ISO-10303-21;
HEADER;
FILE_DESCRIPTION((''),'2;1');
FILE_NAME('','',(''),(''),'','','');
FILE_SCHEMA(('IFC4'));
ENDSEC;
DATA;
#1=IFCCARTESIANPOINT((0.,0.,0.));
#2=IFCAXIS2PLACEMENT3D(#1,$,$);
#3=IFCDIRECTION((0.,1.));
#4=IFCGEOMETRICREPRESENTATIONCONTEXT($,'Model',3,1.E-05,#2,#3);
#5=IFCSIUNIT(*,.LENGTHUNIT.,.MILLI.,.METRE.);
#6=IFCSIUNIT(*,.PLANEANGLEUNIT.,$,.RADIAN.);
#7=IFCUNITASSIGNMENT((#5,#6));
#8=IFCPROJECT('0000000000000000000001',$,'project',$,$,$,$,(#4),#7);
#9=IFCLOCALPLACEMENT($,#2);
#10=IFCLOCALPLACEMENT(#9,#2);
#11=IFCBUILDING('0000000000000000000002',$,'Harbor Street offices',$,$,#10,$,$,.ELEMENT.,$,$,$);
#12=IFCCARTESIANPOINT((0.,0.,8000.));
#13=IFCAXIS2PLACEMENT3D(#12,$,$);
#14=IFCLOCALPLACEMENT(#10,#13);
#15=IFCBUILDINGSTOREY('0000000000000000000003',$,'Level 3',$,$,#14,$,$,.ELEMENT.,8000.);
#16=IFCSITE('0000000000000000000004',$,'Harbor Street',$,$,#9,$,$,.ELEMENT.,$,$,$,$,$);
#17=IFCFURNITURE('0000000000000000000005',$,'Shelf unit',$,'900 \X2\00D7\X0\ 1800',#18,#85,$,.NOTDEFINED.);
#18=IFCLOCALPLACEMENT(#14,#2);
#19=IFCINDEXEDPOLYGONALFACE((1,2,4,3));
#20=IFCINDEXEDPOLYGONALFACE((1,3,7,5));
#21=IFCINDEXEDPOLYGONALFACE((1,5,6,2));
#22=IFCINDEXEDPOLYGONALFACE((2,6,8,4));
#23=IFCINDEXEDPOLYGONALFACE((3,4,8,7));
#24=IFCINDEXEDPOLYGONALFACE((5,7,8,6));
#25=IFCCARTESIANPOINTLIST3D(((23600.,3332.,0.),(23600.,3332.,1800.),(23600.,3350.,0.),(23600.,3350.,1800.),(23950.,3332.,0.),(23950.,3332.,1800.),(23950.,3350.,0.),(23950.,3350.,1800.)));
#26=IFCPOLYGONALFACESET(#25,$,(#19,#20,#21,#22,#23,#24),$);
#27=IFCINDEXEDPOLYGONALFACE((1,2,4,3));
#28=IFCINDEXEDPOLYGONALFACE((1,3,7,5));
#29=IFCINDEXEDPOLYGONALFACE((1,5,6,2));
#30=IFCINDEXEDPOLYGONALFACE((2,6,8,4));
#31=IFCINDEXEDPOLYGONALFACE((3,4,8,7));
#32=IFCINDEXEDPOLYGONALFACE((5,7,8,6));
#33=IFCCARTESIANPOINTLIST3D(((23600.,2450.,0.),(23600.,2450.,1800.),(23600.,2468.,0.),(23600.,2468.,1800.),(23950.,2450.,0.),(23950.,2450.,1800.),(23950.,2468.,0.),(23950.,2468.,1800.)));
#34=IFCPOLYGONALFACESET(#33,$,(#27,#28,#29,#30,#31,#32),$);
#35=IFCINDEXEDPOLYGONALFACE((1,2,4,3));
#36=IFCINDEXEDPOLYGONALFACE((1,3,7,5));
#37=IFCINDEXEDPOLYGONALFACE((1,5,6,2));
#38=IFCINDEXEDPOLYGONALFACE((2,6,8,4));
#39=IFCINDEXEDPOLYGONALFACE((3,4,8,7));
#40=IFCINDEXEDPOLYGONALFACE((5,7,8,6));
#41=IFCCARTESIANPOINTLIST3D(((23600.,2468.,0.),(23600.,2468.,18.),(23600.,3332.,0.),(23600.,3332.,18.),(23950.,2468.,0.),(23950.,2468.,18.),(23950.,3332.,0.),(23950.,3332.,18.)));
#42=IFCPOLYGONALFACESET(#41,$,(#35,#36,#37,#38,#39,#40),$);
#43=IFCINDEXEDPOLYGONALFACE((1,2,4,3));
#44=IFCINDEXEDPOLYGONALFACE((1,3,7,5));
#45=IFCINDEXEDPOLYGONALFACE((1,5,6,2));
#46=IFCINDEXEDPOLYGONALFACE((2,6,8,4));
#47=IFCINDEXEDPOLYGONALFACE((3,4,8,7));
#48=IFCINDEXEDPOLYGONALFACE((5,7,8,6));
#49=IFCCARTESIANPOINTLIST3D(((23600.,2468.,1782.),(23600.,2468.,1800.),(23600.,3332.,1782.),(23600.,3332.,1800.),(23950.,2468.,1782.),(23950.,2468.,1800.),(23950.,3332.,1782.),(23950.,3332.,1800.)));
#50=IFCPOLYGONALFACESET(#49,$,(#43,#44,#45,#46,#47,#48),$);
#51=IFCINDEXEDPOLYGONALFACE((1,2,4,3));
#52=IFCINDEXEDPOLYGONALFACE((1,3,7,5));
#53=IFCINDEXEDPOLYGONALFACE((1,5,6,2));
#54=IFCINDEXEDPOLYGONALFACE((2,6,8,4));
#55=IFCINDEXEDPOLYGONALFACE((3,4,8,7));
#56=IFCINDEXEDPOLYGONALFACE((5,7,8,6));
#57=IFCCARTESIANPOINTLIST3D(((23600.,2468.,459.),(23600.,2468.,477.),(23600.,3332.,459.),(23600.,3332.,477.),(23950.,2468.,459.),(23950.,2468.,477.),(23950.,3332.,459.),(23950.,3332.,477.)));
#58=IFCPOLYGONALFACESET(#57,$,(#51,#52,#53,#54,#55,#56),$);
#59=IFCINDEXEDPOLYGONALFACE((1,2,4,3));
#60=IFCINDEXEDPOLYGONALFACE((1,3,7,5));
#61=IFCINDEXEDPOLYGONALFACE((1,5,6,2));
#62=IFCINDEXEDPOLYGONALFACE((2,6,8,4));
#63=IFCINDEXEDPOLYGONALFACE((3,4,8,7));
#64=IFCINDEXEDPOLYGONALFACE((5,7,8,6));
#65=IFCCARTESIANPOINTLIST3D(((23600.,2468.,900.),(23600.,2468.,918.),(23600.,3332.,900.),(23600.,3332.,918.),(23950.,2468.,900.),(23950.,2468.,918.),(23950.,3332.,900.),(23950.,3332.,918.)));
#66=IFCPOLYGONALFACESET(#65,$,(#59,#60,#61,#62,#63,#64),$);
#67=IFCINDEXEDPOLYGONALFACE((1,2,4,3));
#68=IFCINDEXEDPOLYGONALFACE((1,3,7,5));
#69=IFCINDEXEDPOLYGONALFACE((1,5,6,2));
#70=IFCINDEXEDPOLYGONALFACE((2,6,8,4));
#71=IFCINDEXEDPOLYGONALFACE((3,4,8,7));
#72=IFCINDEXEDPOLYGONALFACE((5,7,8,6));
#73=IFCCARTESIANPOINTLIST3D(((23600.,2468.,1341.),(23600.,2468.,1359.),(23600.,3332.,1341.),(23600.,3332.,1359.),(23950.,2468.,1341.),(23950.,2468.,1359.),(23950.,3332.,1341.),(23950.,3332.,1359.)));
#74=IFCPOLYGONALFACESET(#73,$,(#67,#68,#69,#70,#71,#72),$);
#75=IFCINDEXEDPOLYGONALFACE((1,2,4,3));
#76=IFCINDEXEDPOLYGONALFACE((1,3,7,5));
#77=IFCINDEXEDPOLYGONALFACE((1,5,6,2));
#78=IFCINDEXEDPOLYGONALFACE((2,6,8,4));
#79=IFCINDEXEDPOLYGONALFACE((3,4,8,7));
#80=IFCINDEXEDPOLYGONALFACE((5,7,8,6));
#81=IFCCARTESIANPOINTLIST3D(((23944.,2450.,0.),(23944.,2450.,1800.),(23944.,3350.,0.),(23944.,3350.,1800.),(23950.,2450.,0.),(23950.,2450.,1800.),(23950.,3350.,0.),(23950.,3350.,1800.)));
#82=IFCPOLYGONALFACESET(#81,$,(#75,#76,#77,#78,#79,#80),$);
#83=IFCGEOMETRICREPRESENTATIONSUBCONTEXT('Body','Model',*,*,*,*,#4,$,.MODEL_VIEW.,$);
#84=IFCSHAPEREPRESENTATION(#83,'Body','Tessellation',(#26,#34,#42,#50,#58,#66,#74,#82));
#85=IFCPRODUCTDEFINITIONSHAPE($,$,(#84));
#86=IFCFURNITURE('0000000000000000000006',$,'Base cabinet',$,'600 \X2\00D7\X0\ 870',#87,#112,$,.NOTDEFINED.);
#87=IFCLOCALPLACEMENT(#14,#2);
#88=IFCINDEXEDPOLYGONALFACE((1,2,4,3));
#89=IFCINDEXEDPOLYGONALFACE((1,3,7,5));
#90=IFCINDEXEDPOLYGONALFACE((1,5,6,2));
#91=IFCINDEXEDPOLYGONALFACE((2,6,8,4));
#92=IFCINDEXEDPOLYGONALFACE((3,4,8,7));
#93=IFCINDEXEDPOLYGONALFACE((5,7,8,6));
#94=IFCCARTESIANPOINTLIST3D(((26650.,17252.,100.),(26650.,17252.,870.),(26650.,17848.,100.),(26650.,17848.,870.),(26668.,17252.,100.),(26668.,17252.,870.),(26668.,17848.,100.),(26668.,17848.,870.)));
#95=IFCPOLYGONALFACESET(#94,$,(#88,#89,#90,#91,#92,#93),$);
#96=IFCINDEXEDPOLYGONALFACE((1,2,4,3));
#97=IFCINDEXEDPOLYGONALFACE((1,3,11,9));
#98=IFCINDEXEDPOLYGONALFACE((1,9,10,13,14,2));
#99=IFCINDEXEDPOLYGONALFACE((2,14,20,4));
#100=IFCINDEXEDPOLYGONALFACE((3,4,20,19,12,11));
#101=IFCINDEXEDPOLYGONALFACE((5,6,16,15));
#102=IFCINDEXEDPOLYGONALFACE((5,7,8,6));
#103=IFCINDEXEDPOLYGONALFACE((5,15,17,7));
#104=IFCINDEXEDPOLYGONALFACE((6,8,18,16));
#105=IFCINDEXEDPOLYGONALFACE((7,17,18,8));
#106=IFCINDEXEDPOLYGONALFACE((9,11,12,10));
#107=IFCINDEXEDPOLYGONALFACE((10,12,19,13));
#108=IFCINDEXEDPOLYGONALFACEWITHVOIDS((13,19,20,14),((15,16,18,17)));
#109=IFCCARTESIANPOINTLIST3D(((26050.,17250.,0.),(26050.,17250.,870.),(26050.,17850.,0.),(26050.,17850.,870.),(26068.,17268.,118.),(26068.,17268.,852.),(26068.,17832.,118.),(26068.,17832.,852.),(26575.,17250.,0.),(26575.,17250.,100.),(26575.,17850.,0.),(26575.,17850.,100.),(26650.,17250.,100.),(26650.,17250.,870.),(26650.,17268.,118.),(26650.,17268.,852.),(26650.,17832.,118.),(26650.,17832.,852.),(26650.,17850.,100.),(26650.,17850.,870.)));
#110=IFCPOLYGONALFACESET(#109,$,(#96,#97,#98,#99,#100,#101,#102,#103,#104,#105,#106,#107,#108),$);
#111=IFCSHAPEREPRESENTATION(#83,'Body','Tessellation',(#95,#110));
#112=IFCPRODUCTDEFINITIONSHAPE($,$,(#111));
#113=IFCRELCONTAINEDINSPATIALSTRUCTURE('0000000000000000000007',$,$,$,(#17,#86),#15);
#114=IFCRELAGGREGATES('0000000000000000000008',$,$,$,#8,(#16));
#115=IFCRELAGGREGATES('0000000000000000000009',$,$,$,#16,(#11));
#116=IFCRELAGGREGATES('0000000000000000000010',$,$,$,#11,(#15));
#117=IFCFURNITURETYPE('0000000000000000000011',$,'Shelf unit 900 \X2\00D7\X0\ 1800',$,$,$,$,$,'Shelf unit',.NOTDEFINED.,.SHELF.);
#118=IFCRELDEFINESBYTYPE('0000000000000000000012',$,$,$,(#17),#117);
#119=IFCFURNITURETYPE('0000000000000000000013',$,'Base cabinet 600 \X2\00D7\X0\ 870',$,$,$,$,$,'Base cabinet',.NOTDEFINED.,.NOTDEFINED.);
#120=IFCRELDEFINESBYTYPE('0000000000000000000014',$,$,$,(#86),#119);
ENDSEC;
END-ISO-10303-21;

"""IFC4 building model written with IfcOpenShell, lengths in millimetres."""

from ifc_helpers import new_model, entity, si_unit, direction, frame, origin, place, context, subcontext, project, spatial, polyline, outline, extrude, source, transform, mapped, type_object, type_shapes, element, save


model = new_model("IFC4")

# Units and contexts
model_context = context("Model", 3, precision=1e-05, world=origin(), true_north=direction((0.0, 1.0)))
body_context = subcontext(model_context, "Body", "Model", "MODEL_VIEW")
ifc_project = project(units=[si_unit("LENGTHUNIT", "METRE", prefix="MILLI"), si_unit("PLANEANGLEUNIT", "RADIAN")], contexts=[model_context])

# Site, building, storey
site_placement = place(None, origin())
site = spatial("IfcSite", under=ifc_project, at=site_placement, Name="Harbor Street", CompositionType="ELEMENT")
building_placement = place(site_placement, origin())
building = spatial("IfcBuilding", under=site, at=building_placement, Name="Harbor Street offices", CompositionType="ELEMENT")
storey_placement = place(building_placement, frame((0.0, 0.0, 8000.0)))
storey = spatial("IfcBuildingStorey", under=building, at=storey_placement, Name="Level 3", CompositionType="ELEMENT", Elevation=8000.0)

# Furniture
furniture_type_1 = type_object("IfcFurnitureType", Name="Shelf unit 900 × 1800", ElementType="Shelf unit", AssemblyPlace="NOTDEFINED", PredefinedType="SHELF")
shared_shape_1 = source(origin(), body_context, "Body", "SweptSolid", [
    extrude(outline(polyline([(-450.0, 0.0), (-432.0, 0.0), (-432.0, 350.0), (-450.0, 350.0), (-450.0, 0.0)])), origin(), (0.0, 0.0, 1.0), 1800.0),
    extrude(outline(polyline([(432.0, 0.0), (450.0, 0.0), (450.0, 350.0), (432.0, 350.0), (432.0, 0.0)])), origin(), (0.0, 0.0, 1.0), 1800.0),
    extrude(outline(polyline([(-432.0, 0.0), (432.0, 0.0), (432.0, 350.0), (-432.0, 350.0), (-432.0, 0.0)])), origin(), (0.0, 0.0, 1.0), 18.0),
    extrude(outline(polyline([(-432.0, 0.0), (432.0, 0.0), (432.0, 350.0), (-432.0, 350.0), (-432.0, 0.0)])), frame((0.0, 0.0, 1782.0)), (0.0, 0.0, 1.0), 18.0),
    extrude(outline(polyline([(-432.0, 0.0), (432.0, 0.0), (432.0, 350.0), (-432.0, 350.0), (-432.0, 0.0)])), frame((0.0, 0.0, 459.0)), (0.0, 0.0, 1.0), 18.0),
    extrude(outline(polyline([(-432.0, 0.0), (432.0, 0.0), (432.0, 350.0), (-432.0, 350.0), (-432.0, 0.0)])), frame((0.0, 0.0, 900.0)), (0.0, 0.0, 1.0), 18.0),
    extrude(outline(polyline([(-432.0, 0.0), (432.0, 0.0), (432.0, 350.0), (-432.0, 350.0), (-432.0, 0.0)])), frame((0.0, 0.0, 1341.0)), (0.0, 0.0, 1.0), 18.0),
    extrude(outline(polyline([(-450.0, 344.0), (450.0, 344.0), (450.0, 350.0), (-450.0, 350.0), (-450.0, 344.0)])), origin(), (0.0, 0.0, 1.0), 1800.0),
])
type_shapes(furniture_type_1, [shared_shape_1])
for number, where, z_axis, x_axis, name in (
    (1, (23600.0, 2900.0, 0.0), (0.0, 0.0, 1.0), (0.0, -1.0, 0.0), "Shelf unit"),
):
    element("IfcFurniture", number, at=place(storey_placement, frame(where, z_axis=z_axis, x_axis=x_axis)), inside=storey, type_object=furniture_type_1, Name=name, ObjectType="900 × 1800", PredefinedType="NOTDEFINED", context=body_context, shape_type="MappedRepresentation", body=[
        mapped(shared_shape_1, transform((0.0, 0.0, 0.0))),
    ])
furniture_type_2 = type_object("IfcFurnitureType", Name="Base cabinet 600 × 870", ElementType="Base cabinet", AssemblyPlace="NOTDEFINED", PredefinedType="NOTDEFINED")
cartesian_point_1 = entity("IfcCartesianPoint", [-300.0, 0.0])
cartesian_point_2 = entity("IfcCartesianPoint", [-282.0, -1.0])
cartesian_point_3 = entity("IfcCartesianPoint", [-301.0, -1.0])
shared_shape_2 = source(origin(), body_context, "Body", "SolidModel", [
    extrude(outline(polyline([(-298.0, -18.0), (298.0, -18.0), (298.0, 0.0), (-298.0, 0.0), (-298.0, -18.0)])), frame((0.0, 0.0, 100.0)), (0.0, 0.0, 1.0), 770.0),
    entity("IfcCsgSolid", entity("IfcBooleanResult", "DIFFERENCE", entity("IfcBooleanResult", "DIFFERENCE", entity("IfcExtrudedAreaSolid", entity("IfcArbitraryClosedProfileDef", "AREA", None, entity("IfcPolyline", [cartesian_point_1, entity("IfcCartesianPoint", [300.0, 0.0]), entity("IfcCartesianPoint", [300.0, 600.0]), entity("IfcCartesianPoint", [-300.0, 600.0]), cartesian_point_1])), entity("IfcAxis2Placement3D", entity("IfcCartesianPoint", [0.0, 0.0, 0.0])), entity("IfcDirection", [0.0, 0.0, 1.0]), 870.0), entity("IfcExtrudedAreaSolid", entity("IfcArbitraryClosedProfileDef", "AREA", None, entity("IfcPolyline", [cartesian_point_2, entity("IfcCartesianPoint", [282.0, -1.0]), entity("IfcCartesianPoint", [282.0, 582.0]), entity("IfcCartesianPoint", [-282.0, 582.0]), cartesian_point_2])), entity("IfcAxis2Placement3D", entity("IfcCartesianPoint", [0.0, 0.0, 118.0])), entity("IfcDirection", [0.0, 0.0, 1.0]), 734.0)), entity("IfcExtrudedAreaSolid", entity("IfcArbitraryClosedProfileDef", "AREA", None, entity("IfcPolyline", [cartesian_point_3, entity("IfcCartesianPoint", [301.0, -1.0]), entity("IfcCartesianPoint", [301.0, 75.0]), entity("IfcCartesianPoint", [-301.0, 75.0]), cartesian_point_3])), entity("IfcAxis2Placement3D", entity("IfcCartesianPoint", [0.0, 0.0, -1.0])), entity("IfcDirection", [0.0, 0.0, 1.0]), 101.0))),
])
type_shapes(furniture_type_2, [shared_shape_2])
furniture_placement = place(storey_placement, frame((26650.0, 17550.0, 0.0), z_axis=(0.0, 0.0, 1.0), x_axis=(0.0, 1.0, 0.0)))
element("IfcFurniture", 2, at=furniture_placement, inside=storey, type_object=furniture_type_2, Name="Base cabinet", ObjectType="600 × 870", PredefinedType="NOTDEFINED", context=body_context, shape_type="MappedRepresentation", body=[
    mapped(shared_shape_2, transform((0.0, 0.0, 0.0))),
])

save(model, "model.ifc")
